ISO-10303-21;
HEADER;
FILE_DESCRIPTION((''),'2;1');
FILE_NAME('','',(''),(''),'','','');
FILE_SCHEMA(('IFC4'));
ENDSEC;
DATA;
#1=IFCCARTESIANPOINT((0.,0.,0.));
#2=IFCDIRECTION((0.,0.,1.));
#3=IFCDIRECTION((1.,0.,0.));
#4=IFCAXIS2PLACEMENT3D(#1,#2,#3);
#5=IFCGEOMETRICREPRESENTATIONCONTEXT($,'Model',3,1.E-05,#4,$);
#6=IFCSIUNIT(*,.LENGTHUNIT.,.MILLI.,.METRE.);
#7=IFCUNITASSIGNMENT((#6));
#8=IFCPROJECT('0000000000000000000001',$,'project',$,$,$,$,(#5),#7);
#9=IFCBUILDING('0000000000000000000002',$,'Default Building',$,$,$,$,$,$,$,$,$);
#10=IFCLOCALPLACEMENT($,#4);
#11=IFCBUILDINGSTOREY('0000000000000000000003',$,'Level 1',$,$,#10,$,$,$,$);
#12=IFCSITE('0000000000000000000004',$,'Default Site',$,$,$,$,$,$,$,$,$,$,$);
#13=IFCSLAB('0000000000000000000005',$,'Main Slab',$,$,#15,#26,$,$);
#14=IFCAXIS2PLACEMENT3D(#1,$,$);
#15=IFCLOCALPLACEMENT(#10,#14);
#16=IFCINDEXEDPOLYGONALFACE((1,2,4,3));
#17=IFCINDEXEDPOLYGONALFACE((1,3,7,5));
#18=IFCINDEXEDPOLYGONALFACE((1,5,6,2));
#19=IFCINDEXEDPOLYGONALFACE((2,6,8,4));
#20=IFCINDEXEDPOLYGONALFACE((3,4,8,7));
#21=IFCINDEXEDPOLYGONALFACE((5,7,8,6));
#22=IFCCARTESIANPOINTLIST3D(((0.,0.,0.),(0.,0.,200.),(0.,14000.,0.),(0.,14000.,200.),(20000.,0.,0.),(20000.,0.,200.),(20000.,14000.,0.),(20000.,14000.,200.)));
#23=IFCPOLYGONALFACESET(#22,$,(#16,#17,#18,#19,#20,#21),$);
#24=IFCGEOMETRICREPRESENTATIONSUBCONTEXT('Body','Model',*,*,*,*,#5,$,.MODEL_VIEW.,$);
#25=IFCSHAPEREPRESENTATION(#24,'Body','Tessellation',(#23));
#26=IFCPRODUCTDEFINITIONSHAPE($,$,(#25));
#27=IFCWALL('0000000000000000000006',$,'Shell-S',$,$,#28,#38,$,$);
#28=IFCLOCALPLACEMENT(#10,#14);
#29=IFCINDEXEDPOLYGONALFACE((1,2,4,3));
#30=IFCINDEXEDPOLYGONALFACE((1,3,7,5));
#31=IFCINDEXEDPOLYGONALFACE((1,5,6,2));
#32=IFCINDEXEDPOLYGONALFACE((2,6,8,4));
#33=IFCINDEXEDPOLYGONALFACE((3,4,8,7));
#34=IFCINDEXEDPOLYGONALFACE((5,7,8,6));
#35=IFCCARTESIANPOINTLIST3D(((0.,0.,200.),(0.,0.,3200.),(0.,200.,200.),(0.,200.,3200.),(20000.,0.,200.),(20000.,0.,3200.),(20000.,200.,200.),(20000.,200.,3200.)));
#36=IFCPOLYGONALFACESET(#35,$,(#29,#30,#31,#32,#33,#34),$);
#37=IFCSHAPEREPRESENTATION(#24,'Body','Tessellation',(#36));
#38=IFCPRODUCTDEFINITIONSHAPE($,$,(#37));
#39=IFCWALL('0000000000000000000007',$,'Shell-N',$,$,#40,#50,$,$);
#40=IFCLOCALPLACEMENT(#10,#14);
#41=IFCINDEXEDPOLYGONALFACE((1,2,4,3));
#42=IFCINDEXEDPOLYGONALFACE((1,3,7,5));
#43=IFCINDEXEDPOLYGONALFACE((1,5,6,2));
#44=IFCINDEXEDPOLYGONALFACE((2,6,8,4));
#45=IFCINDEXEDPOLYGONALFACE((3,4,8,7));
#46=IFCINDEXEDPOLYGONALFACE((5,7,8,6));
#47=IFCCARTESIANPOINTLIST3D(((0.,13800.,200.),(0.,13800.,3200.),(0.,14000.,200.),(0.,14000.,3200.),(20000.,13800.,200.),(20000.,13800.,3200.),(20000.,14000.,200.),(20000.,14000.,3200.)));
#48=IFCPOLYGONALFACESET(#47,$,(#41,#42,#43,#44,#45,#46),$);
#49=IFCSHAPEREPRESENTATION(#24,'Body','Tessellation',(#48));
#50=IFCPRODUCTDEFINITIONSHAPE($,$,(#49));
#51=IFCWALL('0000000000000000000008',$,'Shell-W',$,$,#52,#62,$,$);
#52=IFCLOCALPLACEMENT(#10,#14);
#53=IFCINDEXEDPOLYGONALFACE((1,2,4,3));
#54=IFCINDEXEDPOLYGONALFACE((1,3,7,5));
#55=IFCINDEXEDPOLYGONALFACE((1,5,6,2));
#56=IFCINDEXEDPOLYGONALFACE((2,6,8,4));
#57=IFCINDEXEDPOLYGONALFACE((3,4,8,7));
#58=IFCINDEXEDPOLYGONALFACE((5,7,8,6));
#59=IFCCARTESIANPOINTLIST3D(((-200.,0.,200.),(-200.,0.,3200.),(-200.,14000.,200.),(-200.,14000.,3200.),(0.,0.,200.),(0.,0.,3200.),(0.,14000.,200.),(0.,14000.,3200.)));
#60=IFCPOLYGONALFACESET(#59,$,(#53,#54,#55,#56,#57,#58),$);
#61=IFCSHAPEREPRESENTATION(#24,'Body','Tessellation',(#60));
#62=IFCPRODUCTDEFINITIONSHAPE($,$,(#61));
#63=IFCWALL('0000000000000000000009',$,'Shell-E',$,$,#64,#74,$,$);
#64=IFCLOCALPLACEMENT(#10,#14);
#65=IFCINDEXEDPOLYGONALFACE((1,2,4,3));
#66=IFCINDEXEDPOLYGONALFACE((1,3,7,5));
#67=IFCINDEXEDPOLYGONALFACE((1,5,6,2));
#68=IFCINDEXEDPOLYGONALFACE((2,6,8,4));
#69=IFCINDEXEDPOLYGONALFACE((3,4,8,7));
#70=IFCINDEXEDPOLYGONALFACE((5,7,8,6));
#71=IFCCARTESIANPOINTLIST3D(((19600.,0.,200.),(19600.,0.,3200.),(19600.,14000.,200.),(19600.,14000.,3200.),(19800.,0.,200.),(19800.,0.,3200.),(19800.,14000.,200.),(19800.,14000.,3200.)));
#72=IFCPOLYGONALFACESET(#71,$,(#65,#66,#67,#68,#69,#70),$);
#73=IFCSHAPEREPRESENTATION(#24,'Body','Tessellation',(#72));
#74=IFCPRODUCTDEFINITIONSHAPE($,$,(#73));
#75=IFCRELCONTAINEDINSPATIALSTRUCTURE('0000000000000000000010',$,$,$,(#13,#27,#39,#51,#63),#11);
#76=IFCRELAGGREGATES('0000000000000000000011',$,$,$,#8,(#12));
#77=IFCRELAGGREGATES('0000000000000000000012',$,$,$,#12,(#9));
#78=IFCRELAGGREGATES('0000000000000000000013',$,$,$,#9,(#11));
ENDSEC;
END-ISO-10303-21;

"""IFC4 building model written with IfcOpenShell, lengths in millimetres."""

from ifc_helpers import new_model, si_unit, frame, origin_with_axes, place, context, subcontext, project, spatial, indexed_curve, outline, extrude, element, save


model = new_model("IFC4")

# Units and contexts
model_context = context("Model", 3, precision=1e-05, world=origin_with_axes())
body_context = subcontext(model_context, "Body", "Model", "MODEL_VIEW")
ifc_project = project(units=[si_unit("LENGTHUNIT", "METRE", prefix="MILLI")], contexts=[model_context])

# Site, building, storey
site = spatial("IfcSite", under=ifc_project, Name="Default Site")
building = spatial("IfcBuilding", under=site, Name="Default Building")
storey_placement = place(None, origin_with_axes())
storey = spatial("IfcBuildingStorey", under=building, at=storey_placement, Name="Level 1")

# Slab
slab_placement = place(storey_placement, origin_with_axes())
element("IfcSlab", 1, at=slab_placement, inside=storey, Name="Main Slab", context=body_context, shape_type="SweptSolid", body=[
    extrude(outline(indexed_curve([(0.0, 0.0), (20000.0, 0.0), (20000.0, 14000.0), (0.0, 14000.0), (0.0, 0.0)])), None, (0.0, 0.0, 1.0), 200.0),
])

# Walls
wall_1_placement = place(storey_placement, frame((0.0, 0.0, 200.0), z_axis=(0.0, 0.0, 1.0), x_axis=(1.0, 0.0, 0.0)))
element("IfcWall", 2, at=wall_1_placement, inside=storey, Name="Shell-S", context=body_context, shape_type="SweptSolid", body=[
    extrude(outline(indexed_curve([(0.0, 0.0), (20000.0, 0.0), (20000.0, 200.0), (0.0, 200.0), (0.0, 0.0)])), None, (0.0, 0.0, 1.0), 3000.0),
])
wall_2_placement = place(storey_placement, frame((0.0, 0.0, 200.0), z_axis=(0.0, 0.0, 1.0), x_axis=(1.0, 0.0, 0.0)))
element("IfcWall", 3, at=wall_2_placement, inside=storey, Name="Shell-N", context=body_context, shape_type="SweptSolid", body=[
    extrude(outline(indexed_curve([(0.0, 13800.0), (20000.0, 13800.0), (20000.0, 14000.0), (0.0, 14000.0), (0.0, 13800.0)])), None, (0.0, 0.0, 1.0), 3000.0),
])
wall_3_placement = place(storey_placement, frame((0.0, 0.0, 200.0), z_axis=(0.0, 0.0, 1.0), x_axis=(1.0, 0.0, 0.0)))
element("IfcWall", 4, at=wall_3_placement, inside=storey, Name="Shell-W", context=body_context, shape_type="SweptSolid", body=[
    extrude(outline(indexed_curve([(0.0, 0.0), (0.0, 14000.0), (-200.0, 14000.0), (-200.0, 0.0), (0.0, 0.0)])), None, (0.0, 0.0, 1.0), 3000.0),
])
wall_4_placement = place(storey_placement, frame((0.0, 0.0, 200.0), z_axis=(0.0, 0.0, 1.0), x_axis=(1.0, 0.0, 0.0)))
element("IfcWall", 5, at=wall_4_placement, inside=storey, Name="Shell-E", context=body_context, shape_type="SweptSolid", body=[
    extrude(outline(indexed_curve([(19800.0, 0.0), (19800.0, 14000.0), (19600.0, 14000.0), (19600.0, 0.0), (19800.0, 0.0)])), None, (0.0, 0.0, 1.0), 3000.0),
])

save(model, "model.ifc")
